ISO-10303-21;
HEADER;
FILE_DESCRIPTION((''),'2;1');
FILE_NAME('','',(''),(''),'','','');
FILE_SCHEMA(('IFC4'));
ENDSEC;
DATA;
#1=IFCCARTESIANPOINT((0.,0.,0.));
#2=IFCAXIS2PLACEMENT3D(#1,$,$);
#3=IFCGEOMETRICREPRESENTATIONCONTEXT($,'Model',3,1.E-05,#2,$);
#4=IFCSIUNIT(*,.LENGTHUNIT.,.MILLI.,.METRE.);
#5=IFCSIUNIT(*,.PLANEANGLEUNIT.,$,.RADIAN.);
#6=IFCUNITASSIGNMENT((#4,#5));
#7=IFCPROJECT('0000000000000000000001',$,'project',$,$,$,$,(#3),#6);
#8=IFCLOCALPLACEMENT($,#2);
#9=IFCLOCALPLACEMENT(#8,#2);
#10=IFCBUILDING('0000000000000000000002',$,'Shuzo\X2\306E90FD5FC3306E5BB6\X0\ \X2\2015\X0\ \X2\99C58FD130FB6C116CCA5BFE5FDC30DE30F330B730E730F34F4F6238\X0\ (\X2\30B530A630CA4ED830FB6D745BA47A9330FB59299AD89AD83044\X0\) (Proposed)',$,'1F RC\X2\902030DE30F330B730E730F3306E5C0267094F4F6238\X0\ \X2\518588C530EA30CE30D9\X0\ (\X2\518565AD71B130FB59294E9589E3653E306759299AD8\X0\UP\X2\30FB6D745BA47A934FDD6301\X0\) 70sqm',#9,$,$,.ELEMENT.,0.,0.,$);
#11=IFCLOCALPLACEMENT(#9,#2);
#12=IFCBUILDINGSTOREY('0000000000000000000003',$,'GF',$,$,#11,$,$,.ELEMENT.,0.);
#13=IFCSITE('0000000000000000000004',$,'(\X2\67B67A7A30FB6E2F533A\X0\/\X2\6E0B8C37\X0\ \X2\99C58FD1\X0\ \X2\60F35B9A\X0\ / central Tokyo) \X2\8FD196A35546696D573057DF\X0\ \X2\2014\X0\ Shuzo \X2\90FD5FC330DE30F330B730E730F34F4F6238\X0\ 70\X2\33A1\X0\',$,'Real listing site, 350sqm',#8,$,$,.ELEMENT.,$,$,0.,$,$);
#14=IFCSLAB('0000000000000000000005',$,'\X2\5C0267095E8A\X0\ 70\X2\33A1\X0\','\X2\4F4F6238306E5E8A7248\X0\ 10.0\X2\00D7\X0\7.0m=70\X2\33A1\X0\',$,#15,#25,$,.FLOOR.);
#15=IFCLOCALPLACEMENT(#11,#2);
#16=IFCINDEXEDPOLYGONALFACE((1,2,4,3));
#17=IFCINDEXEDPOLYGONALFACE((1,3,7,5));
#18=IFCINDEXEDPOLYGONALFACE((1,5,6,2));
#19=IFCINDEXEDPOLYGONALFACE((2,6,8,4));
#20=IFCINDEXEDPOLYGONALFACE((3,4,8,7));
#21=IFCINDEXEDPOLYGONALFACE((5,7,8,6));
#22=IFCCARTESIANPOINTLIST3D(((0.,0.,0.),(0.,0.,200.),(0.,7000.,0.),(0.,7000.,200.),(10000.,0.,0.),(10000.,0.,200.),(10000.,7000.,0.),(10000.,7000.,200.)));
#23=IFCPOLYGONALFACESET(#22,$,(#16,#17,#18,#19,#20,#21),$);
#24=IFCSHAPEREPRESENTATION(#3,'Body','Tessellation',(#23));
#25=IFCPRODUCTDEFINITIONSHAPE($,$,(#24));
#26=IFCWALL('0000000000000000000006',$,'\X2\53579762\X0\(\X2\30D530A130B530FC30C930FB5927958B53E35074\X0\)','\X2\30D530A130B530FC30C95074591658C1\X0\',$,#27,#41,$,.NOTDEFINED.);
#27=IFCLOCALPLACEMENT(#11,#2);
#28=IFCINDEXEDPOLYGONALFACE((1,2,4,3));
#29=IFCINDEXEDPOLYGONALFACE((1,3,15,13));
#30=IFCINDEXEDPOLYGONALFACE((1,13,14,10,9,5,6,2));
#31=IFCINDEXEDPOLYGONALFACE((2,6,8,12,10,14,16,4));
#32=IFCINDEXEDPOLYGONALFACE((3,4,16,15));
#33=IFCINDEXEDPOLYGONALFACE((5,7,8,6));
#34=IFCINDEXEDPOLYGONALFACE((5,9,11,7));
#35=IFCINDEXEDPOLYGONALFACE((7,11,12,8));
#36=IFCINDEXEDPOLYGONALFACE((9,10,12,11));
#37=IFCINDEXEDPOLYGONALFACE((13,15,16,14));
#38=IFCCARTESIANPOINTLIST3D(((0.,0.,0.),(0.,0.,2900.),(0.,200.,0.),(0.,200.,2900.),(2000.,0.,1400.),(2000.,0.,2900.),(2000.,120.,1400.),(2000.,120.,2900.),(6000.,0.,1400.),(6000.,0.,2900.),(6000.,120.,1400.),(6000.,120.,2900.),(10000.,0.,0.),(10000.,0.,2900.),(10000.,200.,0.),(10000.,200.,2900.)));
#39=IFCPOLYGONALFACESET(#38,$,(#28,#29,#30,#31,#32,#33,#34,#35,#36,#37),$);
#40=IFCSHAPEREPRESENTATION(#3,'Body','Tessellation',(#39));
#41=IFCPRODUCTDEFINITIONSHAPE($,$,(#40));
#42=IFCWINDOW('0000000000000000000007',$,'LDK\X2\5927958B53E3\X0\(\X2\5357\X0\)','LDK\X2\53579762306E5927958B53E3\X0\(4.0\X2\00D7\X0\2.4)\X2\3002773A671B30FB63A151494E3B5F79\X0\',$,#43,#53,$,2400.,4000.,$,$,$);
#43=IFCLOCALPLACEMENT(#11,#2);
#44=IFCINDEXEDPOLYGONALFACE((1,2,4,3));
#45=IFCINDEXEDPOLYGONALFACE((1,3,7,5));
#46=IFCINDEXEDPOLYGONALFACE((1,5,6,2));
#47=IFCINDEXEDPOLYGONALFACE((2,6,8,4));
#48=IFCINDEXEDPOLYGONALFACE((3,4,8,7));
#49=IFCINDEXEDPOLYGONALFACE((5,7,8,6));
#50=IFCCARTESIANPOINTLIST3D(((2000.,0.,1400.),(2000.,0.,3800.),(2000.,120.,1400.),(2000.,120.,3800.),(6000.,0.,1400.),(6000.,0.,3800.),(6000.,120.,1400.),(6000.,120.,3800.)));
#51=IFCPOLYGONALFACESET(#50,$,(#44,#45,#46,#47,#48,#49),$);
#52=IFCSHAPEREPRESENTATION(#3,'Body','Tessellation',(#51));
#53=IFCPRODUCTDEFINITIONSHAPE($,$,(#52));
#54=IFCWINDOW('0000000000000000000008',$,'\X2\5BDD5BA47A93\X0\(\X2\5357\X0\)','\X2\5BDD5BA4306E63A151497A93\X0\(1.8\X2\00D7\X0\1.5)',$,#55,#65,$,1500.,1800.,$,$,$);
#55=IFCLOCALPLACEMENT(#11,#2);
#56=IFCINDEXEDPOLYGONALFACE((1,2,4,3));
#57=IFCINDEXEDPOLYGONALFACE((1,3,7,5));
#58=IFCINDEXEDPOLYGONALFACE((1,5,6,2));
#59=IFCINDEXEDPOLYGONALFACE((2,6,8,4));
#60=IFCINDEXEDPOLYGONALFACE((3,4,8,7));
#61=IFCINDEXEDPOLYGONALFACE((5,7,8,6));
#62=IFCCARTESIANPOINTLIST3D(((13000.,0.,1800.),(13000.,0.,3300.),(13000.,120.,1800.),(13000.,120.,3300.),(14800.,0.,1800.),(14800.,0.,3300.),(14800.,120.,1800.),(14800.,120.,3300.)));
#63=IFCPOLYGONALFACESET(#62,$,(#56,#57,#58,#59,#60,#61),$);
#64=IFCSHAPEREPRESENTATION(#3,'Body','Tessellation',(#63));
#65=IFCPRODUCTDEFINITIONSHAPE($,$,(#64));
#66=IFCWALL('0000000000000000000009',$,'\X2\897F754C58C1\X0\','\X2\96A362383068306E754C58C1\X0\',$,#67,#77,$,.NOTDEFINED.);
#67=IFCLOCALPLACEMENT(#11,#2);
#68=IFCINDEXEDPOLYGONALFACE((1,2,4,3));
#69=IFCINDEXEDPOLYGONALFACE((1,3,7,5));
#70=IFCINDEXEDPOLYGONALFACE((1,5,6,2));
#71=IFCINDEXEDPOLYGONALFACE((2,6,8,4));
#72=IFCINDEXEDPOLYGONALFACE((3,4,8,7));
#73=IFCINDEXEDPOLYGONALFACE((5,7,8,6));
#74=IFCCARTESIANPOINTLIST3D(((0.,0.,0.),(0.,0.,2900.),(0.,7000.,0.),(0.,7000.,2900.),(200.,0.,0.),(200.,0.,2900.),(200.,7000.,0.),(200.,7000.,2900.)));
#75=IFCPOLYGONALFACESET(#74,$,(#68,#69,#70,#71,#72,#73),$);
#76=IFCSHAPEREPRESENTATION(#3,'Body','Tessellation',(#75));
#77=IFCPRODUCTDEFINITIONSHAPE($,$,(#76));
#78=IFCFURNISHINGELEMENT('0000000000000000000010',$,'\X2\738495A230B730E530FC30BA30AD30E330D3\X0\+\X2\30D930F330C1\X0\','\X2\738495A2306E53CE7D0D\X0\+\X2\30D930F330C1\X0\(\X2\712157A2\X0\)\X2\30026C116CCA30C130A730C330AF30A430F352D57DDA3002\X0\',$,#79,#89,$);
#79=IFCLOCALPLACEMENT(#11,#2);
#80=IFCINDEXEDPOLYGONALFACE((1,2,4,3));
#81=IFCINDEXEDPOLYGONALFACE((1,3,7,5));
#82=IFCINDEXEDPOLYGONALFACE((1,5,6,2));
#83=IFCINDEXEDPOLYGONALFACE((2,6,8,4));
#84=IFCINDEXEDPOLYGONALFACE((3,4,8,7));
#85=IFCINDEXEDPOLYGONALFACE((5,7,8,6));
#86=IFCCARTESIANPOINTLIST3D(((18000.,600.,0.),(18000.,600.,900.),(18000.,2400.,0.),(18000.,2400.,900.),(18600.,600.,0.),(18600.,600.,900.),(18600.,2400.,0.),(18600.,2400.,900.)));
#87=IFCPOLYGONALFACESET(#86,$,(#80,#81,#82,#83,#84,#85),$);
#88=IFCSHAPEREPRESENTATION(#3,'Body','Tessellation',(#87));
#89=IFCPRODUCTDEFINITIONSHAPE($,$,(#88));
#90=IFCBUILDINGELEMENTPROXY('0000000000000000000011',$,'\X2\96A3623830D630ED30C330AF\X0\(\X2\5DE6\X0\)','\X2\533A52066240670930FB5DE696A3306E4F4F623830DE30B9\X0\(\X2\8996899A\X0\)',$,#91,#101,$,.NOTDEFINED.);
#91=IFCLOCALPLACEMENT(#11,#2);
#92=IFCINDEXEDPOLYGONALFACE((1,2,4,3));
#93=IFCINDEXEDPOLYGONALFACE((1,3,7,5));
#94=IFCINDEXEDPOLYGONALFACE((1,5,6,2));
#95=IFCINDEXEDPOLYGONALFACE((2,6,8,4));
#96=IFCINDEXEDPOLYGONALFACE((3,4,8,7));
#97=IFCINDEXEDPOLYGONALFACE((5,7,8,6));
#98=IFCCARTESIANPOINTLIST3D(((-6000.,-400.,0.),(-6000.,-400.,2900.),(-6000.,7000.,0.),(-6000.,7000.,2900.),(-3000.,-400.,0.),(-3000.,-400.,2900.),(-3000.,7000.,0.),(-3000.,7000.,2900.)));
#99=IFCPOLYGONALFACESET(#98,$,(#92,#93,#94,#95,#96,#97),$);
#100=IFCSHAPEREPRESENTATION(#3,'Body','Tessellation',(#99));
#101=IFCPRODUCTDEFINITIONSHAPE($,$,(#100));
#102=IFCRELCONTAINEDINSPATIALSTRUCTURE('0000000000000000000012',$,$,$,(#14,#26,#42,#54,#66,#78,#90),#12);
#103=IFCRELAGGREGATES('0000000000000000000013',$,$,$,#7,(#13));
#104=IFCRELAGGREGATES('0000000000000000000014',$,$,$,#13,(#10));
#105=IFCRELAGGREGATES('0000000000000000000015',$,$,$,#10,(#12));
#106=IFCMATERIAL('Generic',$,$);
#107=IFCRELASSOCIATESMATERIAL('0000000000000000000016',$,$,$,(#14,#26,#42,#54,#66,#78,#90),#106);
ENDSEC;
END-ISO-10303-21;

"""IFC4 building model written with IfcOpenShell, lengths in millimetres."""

from ifc_helpers import new_model, si_unit, frame, frame_2d, origin, place, context, project, spatial, rectangle, extrude, material, element, fill, save


model = new_model("IFC4")

# Units and contexts
model_context = context("Model", 3, precision=1e-05, world=origin())
ifc_project = project(units=[si_unit("LENGTHUNIT", "METRE", prefix="MILLI"), si_unit("PLANEANGLEUNIT", "RADIAN")], contexts=[model_context])

# Site, building, storey
site_placement = place(None, origin())
site = spatial("IfcSite", under=ifc_project, at=site_placement, Name="(架空・港区/渋谷 駅近 想定 / central Tokyo) 近隣商業地域 — Shuzo 都心マンション住戸 70㎡", ObjectType="Real listing site, 350sqm", CompositionType="ELEMENT", RefElevation=0.0)
building_placement = place(site_placement, origin())
building = spatial("IfcBuilding", under=site, at=building_placement, Name="Shuzoの都心の家 ― 駅近・民泊対応マンション住戸 (サウナ付・浴室窓・天高高い) (Proposed)", ObjectType="1F RC造マンションの専有住戸 内装リノベ (内断熱・天井解放で天高UP・浴室窓保持) 70sqm", CompositionType="ELEMENT", ElevationOfRefHeight=0.0, ElevationOfTerrain=0.0)
storey_placement = place(building_placement, origin())
storey = spatial("IfcBuildingStorey", under=building, at=storey_placement, Name="GF", CompositionType="ELEMENT", Elevation=0.0)

# Slab
ifc_material = material(Name="Generic")
slab_placement = place(storey_placement, origin())
element("IfcSlab", 1, at=slab_placement, inside=storey, material=ifc_material, Name="専有床 70㎡", Description="住戸の床版 10.0×7.0m=70㎡", PredefinedType="FLOOR", context=model_context, shape_type="SweptSolid", body=[
    extrude(rectangle(XDim=10000.0, YDim=7000.0, at=frame_2d((5000.0, 3500.0))), origin(), (0.0, 0.0, 1.0), 200.0),
])

# Wall, openings, windows
wall_1_placement = place(storey_placement, origin())
wall_1 = element("IfcWall", 2, at=wall_1_placement, inside=storey, material=ifc_material, Name="南面(ファサード・大開口側)", Description="ファサード側外壁", PredefinedType="NOTDEFINED", context=model_context, shape_type="SweptSolid", body=[
    extrude(rectangle(XDim=10000.0, YDim=200.0, at=frame_2d((5000.0, 100.0))), origin(), (0.0, 0.0, 1.0), 2900.0),
])
opening_1_placement = place(storey_placement, frame((1000.0, 0.0, 700.0)))
opening_1 = element("IfcOpeningElement", 3, at=opening_1_placement, cuts=wall_1, PredefinedType="NOTDEFINED", context=model_context, shape_type="SweptSolid", body=[
    extrude(rectangle(XDim=4000.0, YDim=120.0, at=frame_2d((2000.0, 60.0))), frame((1000.0, 0.0, 700.0)), (0.0, 0.0, 1.0), 2400.0),
])
opening_2_placement = place(storey_placement, frame((6500.0, 0.0, 900.0)))
opening_2 = element("IfcOpeningElement", 4, at=opening_2_placement, cuts=wall_1, PredefinedType="NOTDEFINED", context=model_context, shape_type="SweptSolid", body=[
    extrude(rectangle(XDim=1800.0, YDim=120.0, at=frame_2d((900.0, 60.0))), frame((6500.0, 0.0, 900.0)), (0.0, 0.0, 1.0), 1500.0),
])
window_1_placement = place(storey_placement, frame((1000.0, 0.0, 700.0)))
window_1 = element("IfcWindow", 5, at=window_1_placement, inside=storey, material=ifc_material, Name="LDK大開口(南)", Description="LDK南面の大開口(4.0×2.4)。眺望・採光主役", OverallHeight=2400.0, OverallWidth=4000.0, context=model_context, shape_type="SweptSolid", body=[
    extrude(rectangle(XDim=4000.0, YDim=120.0, at=frame_2d((2000.0, 60.0))), frame((1000.0, 0.0, 700.0)), (0.0, 0.0, 1.0), 2400.0),
])
fill(opening_1, window_1)
window_2_placement = place(storey_placement, frame((6500.0, 0.0, 900.0)))
window_2 = element("IfcWindow", 6, at=window_2_placement, inside=storey, material=ifc_material, Name="寝室窓(南)", Description="寝室の採光窓(1.8×1.5)", OverallHeight=1500.0, OverallWidth=1800.0, context=model_context, shape_type="SweptSolid", body=[
    extrude(rectangle(XDim=1800.0, YDim=120.0, at=frame_2d((900.0, 60.0))), frame((6500.0, 0.0, 900.0)), (0.0, 0.0, 1.0), 1500.0),
])
fill(opening_2, window_2)

# Wall
wall_2_placement = place(storey_placement, origin())
element("IfcWall", 7, at=wall_2_placement, inside=storey, material=ifc_material, Name="西界壁", Description="隣戸との界壁", PredefinedType="NOTDEFINED", context=model_context, shape_type="SweptSolid", body=[
    extrude(rectangle(XDim=200.0, YDim=7000.0, at=frame_2d((100.0, 3500.0))), origin(), (0.0, 0.0, 1.0), 2900.0),
])

# Furnishing element
furnishing_1_placement = place(storey_placement, frame((9000.0, 300.0, 0.0)))
element("IfcFurnishingElement", 8, at=furnishing_1_placement, inside=storey, material=ifc_material, Name="玄関シューズキャビ+ベンチ", Description="玄関の収納+ベンチ(無垢)。民泊チェックイン動線。", context=model_context, shape_type="SweptSolid", body=[
    extrude(rectangle(XDim=600.0, YDim=1800.0, at=frame_2d((300.0, 900.0))), frame((9000.0, 300.0, 0.0)), (0.0, 0.0, 1.0), 900.0),
])

# Building element proxy
proxy_1_placement = place(storey_placement, frame((-3000.0, -200.0, 0.0)))
element("IfcBuildingElementProxy", 9, at=proxy_1_placement, inside=storey, material=ifc_material, Name="隣戸ブロック(左)", Description="区分所有・左隣の住戸マス(視覚)", PredefinedType="NOTDEFINED", context=model_context, shape_type="SweptSolid", body=[
    extrude(rectangle(XDim=3000.0, YDim=7400.0, at=frame_2d((1500.0, 3700.0))), frame((-3000.0, -200.0, 0.0)), (0.0, 0.0, 1.0), 2900.0),
])

save(model, "model.ifc")
